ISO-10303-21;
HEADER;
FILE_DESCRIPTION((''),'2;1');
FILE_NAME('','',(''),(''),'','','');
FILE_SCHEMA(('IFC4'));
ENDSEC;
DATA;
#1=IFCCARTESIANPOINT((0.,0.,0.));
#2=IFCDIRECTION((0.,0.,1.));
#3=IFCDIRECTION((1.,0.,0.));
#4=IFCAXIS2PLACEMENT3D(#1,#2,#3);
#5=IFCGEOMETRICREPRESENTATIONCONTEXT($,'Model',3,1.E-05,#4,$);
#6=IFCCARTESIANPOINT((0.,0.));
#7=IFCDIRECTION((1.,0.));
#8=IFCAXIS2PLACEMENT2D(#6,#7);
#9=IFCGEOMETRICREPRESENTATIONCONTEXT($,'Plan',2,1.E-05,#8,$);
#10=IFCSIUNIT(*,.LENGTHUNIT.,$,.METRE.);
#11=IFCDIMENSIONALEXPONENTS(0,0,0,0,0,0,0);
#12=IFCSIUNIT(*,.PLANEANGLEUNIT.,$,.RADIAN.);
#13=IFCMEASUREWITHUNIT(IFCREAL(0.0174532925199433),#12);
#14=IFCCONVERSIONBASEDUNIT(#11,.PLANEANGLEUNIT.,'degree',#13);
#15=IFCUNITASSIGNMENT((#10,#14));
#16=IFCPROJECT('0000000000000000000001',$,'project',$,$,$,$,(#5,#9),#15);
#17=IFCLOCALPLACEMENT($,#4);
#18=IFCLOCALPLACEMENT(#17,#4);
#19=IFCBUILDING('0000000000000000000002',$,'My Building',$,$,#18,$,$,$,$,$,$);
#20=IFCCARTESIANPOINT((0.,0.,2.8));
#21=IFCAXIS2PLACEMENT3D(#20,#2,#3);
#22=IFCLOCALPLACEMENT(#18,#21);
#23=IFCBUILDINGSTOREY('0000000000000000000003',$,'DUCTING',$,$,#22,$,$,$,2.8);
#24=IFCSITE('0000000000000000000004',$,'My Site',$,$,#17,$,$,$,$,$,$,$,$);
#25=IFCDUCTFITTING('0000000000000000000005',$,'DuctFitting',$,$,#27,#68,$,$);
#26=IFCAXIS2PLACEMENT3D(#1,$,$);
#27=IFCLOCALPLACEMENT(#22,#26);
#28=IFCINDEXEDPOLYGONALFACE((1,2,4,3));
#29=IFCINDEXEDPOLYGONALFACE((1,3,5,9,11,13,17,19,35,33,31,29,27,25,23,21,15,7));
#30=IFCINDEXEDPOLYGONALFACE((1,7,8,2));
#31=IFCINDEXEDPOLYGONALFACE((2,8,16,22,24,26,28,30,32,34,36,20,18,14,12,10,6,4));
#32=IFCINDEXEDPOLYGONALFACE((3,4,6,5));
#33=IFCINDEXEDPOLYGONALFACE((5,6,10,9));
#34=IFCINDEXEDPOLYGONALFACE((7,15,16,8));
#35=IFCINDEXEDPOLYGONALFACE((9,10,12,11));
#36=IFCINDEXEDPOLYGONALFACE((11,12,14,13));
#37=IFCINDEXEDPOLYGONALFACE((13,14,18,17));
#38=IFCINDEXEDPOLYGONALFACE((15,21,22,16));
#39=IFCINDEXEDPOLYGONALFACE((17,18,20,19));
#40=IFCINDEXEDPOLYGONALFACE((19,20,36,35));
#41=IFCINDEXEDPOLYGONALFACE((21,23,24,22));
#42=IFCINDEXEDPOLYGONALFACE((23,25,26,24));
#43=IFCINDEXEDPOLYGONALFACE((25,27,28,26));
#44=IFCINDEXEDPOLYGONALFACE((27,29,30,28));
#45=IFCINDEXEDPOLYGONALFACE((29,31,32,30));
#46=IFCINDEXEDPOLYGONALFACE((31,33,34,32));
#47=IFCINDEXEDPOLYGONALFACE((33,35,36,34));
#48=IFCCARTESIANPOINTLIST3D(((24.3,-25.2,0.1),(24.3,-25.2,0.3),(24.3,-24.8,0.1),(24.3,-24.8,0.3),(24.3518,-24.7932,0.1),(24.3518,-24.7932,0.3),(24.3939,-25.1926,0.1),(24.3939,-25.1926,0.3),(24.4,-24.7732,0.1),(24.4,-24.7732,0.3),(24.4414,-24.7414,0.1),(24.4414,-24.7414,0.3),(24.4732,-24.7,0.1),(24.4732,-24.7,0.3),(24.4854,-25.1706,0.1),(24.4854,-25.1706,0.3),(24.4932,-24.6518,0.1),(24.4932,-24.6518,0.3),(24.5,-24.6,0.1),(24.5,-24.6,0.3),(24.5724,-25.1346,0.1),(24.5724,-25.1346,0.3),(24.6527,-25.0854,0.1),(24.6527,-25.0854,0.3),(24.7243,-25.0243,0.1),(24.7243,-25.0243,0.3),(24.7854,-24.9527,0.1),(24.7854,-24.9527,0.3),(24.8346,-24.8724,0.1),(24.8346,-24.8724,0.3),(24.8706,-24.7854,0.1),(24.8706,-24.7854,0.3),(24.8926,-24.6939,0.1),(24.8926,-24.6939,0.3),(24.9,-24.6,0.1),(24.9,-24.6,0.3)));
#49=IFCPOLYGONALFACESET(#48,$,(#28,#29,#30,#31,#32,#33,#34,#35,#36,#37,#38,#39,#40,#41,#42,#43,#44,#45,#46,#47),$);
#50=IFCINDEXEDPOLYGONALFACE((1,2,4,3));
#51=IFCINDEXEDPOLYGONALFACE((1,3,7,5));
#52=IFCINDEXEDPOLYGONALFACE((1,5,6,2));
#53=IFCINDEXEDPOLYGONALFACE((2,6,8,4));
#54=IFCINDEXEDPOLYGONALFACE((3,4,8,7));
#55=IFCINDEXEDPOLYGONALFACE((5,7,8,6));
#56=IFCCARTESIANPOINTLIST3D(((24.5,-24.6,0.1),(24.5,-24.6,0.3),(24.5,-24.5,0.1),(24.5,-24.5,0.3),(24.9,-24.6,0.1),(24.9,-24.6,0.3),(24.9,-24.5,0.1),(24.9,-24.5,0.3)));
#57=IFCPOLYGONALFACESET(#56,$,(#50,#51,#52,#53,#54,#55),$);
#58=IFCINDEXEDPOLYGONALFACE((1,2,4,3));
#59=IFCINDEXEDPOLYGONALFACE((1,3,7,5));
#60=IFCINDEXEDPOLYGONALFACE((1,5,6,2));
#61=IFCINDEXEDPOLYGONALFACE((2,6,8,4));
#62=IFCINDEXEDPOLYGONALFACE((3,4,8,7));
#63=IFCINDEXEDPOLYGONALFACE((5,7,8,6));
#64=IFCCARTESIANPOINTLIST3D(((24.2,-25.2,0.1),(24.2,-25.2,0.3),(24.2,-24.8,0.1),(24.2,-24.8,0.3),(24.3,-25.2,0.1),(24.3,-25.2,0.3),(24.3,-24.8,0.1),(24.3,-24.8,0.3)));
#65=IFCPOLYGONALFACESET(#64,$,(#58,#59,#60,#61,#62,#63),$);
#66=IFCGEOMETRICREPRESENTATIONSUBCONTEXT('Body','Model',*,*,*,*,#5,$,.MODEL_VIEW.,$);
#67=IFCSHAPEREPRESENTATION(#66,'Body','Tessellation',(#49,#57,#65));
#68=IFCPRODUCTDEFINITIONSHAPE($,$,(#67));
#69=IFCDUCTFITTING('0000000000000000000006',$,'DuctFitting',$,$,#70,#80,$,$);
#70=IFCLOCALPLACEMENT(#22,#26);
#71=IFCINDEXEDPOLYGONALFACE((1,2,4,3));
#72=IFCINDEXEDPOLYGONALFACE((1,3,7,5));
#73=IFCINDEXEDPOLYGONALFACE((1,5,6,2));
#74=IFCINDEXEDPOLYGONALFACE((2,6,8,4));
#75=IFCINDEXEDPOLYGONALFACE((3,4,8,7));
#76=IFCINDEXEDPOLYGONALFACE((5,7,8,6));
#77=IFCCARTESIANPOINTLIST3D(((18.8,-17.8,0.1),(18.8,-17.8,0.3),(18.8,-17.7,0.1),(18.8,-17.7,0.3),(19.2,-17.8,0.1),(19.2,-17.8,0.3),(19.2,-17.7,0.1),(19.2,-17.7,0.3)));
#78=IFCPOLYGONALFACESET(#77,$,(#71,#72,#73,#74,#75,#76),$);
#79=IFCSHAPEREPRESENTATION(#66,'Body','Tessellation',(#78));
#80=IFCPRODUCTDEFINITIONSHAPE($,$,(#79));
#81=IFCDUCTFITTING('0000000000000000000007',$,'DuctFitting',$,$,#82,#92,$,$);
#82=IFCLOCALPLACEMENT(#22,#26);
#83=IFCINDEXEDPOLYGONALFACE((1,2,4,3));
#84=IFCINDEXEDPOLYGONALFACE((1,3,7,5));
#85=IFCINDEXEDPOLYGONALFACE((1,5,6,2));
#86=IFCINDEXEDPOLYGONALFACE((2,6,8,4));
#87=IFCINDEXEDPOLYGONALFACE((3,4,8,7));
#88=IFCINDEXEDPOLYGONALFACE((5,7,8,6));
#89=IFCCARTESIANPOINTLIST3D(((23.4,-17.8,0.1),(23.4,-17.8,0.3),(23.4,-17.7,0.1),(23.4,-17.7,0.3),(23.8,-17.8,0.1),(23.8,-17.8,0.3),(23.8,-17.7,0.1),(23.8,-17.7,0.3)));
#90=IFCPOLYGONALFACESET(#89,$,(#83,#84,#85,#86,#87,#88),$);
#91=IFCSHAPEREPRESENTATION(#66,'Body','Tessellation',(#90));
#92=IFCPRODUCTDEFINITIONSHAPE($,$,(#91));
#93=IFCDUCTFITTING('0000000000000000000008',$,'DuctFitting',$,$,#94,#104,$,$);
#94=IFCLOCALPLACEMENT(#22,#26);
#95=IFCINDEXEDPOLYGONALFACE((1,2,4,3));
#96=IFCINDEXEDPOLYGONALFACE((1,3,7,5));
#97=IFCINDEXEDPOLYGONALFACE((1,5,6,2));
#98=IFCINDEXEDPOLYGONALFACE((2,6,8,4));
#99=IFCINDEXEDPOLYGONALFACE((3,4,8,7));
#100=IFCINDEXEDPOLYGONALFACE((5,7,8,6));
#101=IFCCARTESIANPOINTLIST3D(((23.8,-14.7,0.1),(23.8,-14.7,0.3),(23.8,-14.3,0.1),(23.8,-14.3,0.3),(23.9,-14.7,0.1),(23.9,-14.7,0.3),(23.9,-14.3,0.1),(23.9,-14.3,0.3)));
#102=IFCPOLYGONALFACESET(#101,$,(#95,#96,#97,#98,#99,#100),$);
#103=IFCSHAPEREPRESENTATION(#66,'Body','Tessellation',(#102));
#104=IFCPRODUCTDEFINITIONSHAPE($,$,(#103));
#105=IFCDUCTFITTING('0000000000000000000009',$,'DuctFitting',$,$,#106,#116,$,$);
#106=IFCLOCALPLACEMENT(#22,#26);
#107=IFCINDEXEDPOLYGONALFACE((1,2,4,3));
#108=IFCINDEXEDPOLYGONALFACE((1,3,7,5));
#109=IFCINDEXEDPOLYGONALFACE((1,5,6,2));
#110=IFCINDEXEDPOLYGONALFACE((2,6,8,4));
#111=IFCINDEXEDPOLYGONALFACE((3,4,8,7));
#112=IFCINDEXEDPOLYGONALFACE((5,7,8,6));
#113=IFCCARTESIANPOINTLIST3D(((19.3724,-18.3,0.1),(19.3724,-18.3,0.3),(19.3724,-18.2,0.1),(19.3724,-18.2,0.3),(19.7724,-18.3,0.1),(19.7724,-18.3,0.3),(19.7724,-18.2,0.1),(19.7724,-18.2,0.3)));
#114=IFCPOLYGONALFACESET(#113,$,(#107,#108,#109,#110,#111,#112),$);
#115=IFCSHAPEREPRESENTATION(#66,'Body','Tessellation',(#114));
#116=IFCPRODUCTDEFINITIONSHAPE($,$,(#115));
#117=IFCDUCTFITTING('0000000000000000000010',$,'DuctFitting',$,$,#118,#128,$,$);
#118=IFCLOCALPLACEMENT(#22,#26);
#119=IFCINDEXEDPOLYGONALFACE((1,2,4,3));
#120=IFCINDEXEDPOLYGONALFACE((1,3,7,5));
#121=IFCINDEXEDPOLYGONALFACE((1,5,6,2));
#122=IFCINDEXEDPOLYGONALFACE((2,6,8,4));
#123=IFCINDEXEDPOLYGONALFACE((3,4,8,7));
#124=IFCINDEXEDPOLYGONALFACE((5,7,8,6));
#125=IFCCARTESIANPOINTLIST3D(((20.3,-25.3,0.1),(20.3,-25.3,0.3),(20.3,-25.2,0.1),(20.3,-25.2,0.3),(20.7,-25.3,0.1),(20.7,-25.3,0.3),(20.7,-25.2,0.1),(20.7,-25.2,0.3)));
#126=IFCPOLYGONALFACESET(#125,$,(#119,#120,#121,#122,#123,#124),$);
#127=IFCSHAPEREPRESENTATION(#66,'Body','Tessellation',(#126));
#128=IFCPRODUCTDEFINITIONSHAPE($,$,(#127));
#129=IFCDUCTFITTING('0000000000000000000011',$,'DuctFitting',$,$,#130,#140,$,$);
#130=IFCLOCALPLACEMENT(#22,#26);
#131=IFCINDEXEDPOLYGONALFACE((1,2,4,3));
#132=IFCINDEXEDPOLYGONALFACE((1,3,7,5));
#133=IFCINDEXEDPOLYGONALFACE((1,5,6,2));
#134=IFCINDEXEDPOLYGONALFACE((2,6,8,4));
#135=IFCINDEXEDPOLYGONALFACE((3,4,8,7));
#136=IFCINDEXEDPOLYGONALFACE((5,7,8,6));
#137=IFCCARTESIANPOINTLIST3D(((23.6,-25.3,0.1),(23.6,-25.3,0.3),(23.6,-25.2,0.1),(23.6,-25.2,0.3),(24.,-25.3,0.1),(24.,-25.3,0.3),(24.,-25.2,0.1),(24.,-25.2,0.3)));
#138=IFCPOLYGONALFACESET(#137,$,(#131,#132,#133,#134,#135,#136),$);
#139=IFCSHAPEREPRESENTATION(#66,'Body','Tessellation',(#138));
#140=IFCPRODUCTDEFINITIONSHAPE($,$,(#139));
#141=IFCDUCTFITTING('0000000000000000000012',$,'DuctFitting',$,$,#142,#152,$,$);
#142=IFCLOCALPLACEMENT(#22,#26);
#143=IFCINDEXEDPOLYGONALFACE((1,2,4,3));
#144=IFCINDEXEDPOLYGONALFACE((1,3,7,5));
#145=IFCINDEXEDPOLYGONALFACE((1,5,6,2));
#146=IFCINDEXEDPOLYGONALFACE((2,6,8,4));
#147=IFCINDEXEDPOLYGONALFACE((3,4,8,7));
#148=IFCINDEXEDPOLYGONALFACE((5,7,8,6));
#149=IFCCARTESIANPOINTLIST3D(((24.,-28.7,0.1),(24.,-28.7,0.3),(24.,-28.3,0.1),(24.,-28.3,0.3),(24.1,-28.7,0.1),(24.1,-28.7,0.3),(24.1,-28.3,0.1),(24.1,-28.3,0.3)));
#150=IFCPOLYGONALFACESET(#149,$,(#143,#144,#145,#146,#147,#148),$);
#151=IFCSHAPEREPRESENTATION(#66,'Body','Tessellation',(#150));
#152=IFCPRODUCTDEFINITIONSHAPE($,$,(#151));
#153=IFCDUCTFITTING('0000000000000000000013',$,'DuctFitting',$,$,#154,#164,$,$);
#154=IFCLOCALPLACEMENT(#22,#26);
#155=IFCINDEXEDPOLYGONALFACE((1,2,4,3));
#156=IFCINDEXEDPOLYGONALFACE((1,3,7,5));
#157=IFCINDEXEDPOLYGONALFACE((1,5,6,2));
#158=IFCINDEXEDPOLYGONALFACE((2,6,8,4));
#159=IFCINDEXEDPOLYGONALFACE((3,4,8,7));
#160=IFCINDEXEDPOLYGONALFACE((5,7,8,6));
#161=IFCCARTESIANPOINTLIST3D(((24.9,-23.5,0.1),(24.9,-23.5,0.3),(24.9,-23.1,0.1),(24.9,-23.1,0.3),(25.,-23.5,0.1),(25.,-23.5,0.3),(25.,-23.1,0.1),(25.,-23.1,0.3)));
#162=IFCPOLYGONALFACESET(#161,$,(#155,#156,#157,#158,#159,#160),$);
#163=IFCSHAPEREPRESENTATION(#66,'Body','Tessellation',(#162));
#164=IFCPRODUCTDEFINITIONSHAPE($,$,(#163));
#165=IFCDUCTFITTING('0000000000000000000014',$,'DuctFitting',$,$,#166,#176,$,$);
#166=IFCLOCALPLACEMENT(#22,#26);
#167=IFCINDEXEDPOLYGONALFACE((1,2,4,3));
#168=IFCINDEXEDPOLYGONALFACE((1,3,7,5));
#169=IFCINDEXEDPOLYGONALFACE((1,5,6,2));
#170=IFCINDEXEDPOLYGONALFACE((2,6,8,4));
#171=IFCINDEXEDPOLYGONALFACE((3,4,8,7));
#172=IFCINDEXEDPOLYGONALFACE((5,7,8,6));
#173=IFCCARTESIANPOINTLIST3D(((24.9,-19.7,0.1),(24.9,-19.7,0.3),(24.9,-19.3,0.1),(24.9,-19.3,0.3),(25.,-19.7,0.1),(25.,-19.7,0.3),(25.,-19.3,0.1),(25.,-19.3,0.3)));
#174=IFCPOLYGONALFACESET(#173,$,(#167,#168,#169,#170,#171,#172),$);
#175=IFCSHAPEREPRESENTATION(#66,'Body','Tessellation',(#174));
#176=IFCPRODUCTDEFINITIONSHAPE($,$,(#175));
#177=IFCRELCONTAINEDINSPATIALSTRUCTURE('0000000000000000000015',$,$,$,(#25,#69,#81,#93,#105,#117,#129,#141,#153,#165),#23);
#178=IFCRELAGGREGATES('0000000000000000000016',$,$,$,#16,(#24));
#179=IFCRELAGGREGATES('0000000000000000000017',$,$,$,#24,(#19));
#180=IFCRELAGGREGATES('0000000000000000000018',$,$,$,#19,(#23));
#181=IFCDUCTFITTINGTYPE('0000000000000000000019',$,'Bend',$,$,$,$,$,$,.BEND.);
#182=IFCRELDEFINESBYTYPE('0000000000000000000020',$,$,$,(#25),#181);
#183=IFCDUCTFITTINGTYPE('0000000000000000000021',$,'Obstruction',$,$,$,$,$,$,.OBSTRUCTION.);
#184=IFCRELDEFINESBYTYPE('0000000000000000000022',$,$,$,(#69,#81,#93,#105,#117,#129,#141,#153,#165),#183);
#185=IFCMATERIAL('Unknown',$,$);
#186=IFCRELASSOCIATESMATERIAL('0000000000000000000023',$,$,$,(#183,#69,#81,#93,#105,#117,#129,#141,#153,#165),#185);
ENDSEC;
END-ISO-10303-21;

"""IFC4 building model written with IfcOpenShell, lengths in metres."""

from ifc_helpers import new_model, entity, si_unit, converted_unit, frame, origin_with_axes, origin_2d_with_axis, place, context, subcontext, project, spatial, line, arc, indexed_curve, rectangle, outline, extrude, source, transform, mapped, material, material_profile, profile_set, profile_usage, type_object, type_shapes, element, save


model = new_model("IFC4")

# Units and contexts
model_context = context("Model", 3, precision=1e-05, world=origin_with_axes())
plan_context = context("Plan", 2, precision=1e-05, world=origin_2d_with_axis())
body_context = subcontext(model_context, "Body", "Model", "MODEL_VIEW")
ifc_project = project(units=[si_unit("LENGTHUNIT", "METRE"), converted_unit("PLANEANGLEUNIT", "degree", entity("IfcReal", 0.0174532925199433), si_unit("PLANEANGLEUNIT", "RADIAN"), dimensions=[0, 0, 0, 0, 0, 0, 0])], contexts=[model_context, plan_context])

# Site, building, storey
site_placement = place(None, origin_with_axes())
site = spatial("IfcSite", under=ifc_project, at=site_placement, Name="My Site")
building_placement = place(site_placement, origin_with_axes())
building = spatial("IfcBuilding", under=site, at=building_placement, Name="My Building")
storey_placement = place(building_placement, frame((0.0, 0.0, 2.8), z_axis=(0.0, 0.0, 1.0), x_axis=(1.0, 0.0, 0.0)))
storey = spatial("IfcBuildingStorey", under=building, at=storey_placement, Name="DUCTING", Elevation=2.8)

# Shared definitions
ifc_material = material(Name="Unknown")
ifc_material_profile = material_profile(ifc_material, rectangle(XDim=0.4, YDim=0.2))
ifc_profile_set = profile_set([ifc_material_profile])

# Duct fittings
duct_fitting_type_1 = type_object("IfcDuctFittingType", Name="Bend", PredefinedType="BEND")
shared_shape = source(origin_with_axes(), body_context, "Body", "SweptSolid", [
    extrude(outline(indexed_curve([(-0.2, 0.0), (-0.2586, 0.1414), (-0.4, 0.2), (-0.4, 0.6), (0.0243, 0.4243), (0.2, 0.0)], segments=[arc(1, 2, 3), line(3, 4), arc(4, 5, 6), line(6, 1)])), frame((0.0, -0.1, 0.1), z_axis=(0.0, -1.0, 0.0), x_axis=(1.0, 0.0, 0.0)), (0.0, 0.0, -1.0), 0.2),
    extrude(rectangle(XDim=0.4, YDim=0.2), origin_with_axes(), (0.0, 0.0, 1.0), 0.1),
    extrude(rectangle(XDim=0.4, YDim=0.2), frame((-0.4, 0.0, 0.5), z_axis=(-1.0, 0.0, 0.0), x_axis=(0.0, 0.0, -1.0)), (0.0, 0.0, 1.0), 0.1),
])
type_shapes(duct_fitting_type_1, [shared_shape])
for number, where, z_axis, x_axis, name in (
    (1, (24.7, -24.5, 0.2), (0.0, -1.0, 0.0), (1.0, 0.0, 0.0), "DuctFitting"),
):
    element("IfcDuctFitting", number, at=place(storey_placement, frame(where, z_axis=z_axis, x_axis=x_axis)), inside=storey, type_object=duct_fitting_type_1, Name=name, context=body_context, shape_type="MappedRepresentation", body=[
        mapped(shared_shape, transform((0.0, 0.0, 0.0), x_axis=(1.0, 0.0, 0.0), y_axis=(0.0, 1.0, 0.0), z_axis=(0.0, 0.0, 1.0), scale=1.0)),
    ])
ifc_profile_usage_1 = profile_usage(ifc_profile_set)
duct_fitting_type_2 = type_object("IfcDuctFittingType", Name="Obstruction", PredefinedType="OBSTRUCTION", material=ifc_profile_set)
duct_fitting_1_placement = place(storey_placement, frame((19.0, -17.8, 0.2), z_axis=(0.0, 1.0, 0.0), x_axis=(-1.0, 0.0, 0.0)))
element("IfcDuctFitting", 2, at=duct_fitting_1_placement, inside=storey, type_object=duct_fitting_type_2, material=ifc_profile_usage_1, Name="DuctFitting", context=body_context, shape_type="SweptSolid", body=[
    extrude(rectangle(XDim=0.4, YDim=0.2), origin_with_axes(), (0.0, 0.0, 1.0), 0.1),
])
ifc_profile_usage_2 = profile_usage(ifc_profile_set)
duct_fitting_2_placement = place(storey_placement, frame((23.6, -17.8, 0.2), z_axis=(0.0, 1.0, 0.0), x_axis=(-1.0, 0.0, 0.0)))
element("IfcDuctFitting", 3, at=duct_fitting_2_placement, inside=storey, type_object=duct_fitting_type_2, material=ifc_profile_usage_2, Name="DuctFitting", context=body_context, shape_type="SweptSolid", body=[
    extrude(rectangle(XDim=0.4, YDim=0.2), origin_with_axes(), (0.0, 0.0, 1.0), 0.1),
])
ifc_profile_usage_3 = profile_usage(ifc_profile_set)
duct_fitting_3_placement = place(storey_placement, frame((23.8, -14.5, 0.2), z_axis=(1.0, 0.0, 0.0), x_axis=(0.0, 1.0, 0.0)))
element("IfcDuctFitting", 4, at=duct_fitting_3_placement, inside=storey, type_object=duct_fitting_type_2, material=ifc_profile_usage_3, Name="DuctFitting", context=body_context, shape_type="SweptSolid", body=[
    extrude(rectangle(XDim=0.4, YDim=0.2), origin_with_axes(), (0.0, 0.0, 1.0), 0.1),
])
ifc_profile_usage_4 = profile_usage(ifc_profile_set)
duct_fitting_4_placement = place(storey_placement, frame((19.5724, -18.2, 0.2), z_axis=(0.0, -1.0, 0.0), x_axis=(1.0, 0.0, 0.0)))
element("IfcDuctFitting", 5, at=duct_fitting_4_placement, inside=storey, type_object=duct_fitting_type_2, material=ifc_profile_usage_4, Name="DuctFitting", context=body_context, shape_type="SweptSolid", body=[
    extrude(rectangle(XDim=0.4, YDim=0.2), origin_with_axes(), (0.0, 0.0, 1.0), 0.1),
])
ifc_profile_usage_5 = profile_usage(ifc_profile_set)
duct_fitting_5_placement = place(storey_placement, frame((20.5, -25.2, 0.2), z_axis=(0.0, -1.0, 0.0), x_axis=(1.0, 0.0, 0.0)))
element("IfcDuctFitting", 6, at=duct_fitting_5_placement, inside=storey, type_object=duct_fitting_type_2, material=ifc_profile_usage_5, Name="DuctFitting", context=body_context, shape_type="SweptSolid", body=[
    extrude(rectangle(XDim=0.4, YDim=0.2), origin_with_axes(), (0.0, 0.0, 1.0), 0.1),
])
ifc_profile_usage_6 = profile_usage(ifc_profile_set)
duct_fitting_6_placement = place(storey_placement, frame((23.8, -25.2, 0.2), z_axis=(0.0, -1.0, 0.0), x_axis=(1.0, 0.0, 0.0)))
element("IfcDuctFitting", 7, at=duct_fitting_6_placement, inside=storey, type_object=duct_fitting_type_2, material=ifc_profile_usage_6, Name="DuctFitting", context=body_context, shape_type="SweptSolid", body=[
    extrude(rectangle(XDim=0.4, YDim=0.2), origin_with_axes(), (0.0, 0.0, 1.0), 0.1),
])
ifc_profile_usage_7 = profile_usage(ifc_profile_set)
duct_fitting_7_placement = place(storey_placement, frame((24.0, -28.5, 0.2), z_axis=(1.0, 0.0, 0.0), x_axis=(0.0, 1.0, 0.0)))
element("IfcDuctFitting", 8, at=duct_fitting_7_placement, inside=storey, type_object=duct_fitting_type_2, material=ifc_profile_usage_7, Name="DuctFitting", context=body_context, shape_type="SweptSolid", body=[
    extrude(rectangle(XDim=0.4, YDim=0.2), origin_with_axes(), (0.0, 0.0, 1.0), 0.1),
])
ifc_profile_usage_8 = profile_usage(ifc_profile_set)
duct_fitting_8_placement = place(storey_placement, frame((24.9, -23.3, 0.2), z_axis=(1.0, 0.0, 0.0), x_axis=(0.0, 1.0, 0.0)))
element("IfcDuctFitting", 9, at=duct_fitting_8_placement, inside=storey, type_object=duct_fitting_type_2, material=ifc_profile_usage_8, Name="DuctFitting", context=body_context, shape_type="SweptSolid", body=[
    extrude(rectangle(XDim=0.4, YDim=0.2), origin_with_axes(), (0.0, 0.0, 1.0), 0.1),
])
ifc_profile_usage_9 = profile_usage(ifc_profile_set)
duct_fitting_9_placement = place(storey_placement, frame((24.9, -19.5, 0.2), z_axis=(1.0, 0.0, 0.0), x_axis=(0.0, 1.0, 0.0)))
element("IfcDuctFitting", 10, at=duct_fitting_9_placement, inside=storey, type_object=duct_fitting_type_2, material=ifc_profile_usage_9, Name="DuctFitting", context=body_context, shape_type="SweptSolid", body=[
    extrude(rectangle(XDim=0.4, YDim=0.2), origin_with_axes(), (0.0, 0.0, 1.0), 0.1),
])

save(model, "model.ifc")
